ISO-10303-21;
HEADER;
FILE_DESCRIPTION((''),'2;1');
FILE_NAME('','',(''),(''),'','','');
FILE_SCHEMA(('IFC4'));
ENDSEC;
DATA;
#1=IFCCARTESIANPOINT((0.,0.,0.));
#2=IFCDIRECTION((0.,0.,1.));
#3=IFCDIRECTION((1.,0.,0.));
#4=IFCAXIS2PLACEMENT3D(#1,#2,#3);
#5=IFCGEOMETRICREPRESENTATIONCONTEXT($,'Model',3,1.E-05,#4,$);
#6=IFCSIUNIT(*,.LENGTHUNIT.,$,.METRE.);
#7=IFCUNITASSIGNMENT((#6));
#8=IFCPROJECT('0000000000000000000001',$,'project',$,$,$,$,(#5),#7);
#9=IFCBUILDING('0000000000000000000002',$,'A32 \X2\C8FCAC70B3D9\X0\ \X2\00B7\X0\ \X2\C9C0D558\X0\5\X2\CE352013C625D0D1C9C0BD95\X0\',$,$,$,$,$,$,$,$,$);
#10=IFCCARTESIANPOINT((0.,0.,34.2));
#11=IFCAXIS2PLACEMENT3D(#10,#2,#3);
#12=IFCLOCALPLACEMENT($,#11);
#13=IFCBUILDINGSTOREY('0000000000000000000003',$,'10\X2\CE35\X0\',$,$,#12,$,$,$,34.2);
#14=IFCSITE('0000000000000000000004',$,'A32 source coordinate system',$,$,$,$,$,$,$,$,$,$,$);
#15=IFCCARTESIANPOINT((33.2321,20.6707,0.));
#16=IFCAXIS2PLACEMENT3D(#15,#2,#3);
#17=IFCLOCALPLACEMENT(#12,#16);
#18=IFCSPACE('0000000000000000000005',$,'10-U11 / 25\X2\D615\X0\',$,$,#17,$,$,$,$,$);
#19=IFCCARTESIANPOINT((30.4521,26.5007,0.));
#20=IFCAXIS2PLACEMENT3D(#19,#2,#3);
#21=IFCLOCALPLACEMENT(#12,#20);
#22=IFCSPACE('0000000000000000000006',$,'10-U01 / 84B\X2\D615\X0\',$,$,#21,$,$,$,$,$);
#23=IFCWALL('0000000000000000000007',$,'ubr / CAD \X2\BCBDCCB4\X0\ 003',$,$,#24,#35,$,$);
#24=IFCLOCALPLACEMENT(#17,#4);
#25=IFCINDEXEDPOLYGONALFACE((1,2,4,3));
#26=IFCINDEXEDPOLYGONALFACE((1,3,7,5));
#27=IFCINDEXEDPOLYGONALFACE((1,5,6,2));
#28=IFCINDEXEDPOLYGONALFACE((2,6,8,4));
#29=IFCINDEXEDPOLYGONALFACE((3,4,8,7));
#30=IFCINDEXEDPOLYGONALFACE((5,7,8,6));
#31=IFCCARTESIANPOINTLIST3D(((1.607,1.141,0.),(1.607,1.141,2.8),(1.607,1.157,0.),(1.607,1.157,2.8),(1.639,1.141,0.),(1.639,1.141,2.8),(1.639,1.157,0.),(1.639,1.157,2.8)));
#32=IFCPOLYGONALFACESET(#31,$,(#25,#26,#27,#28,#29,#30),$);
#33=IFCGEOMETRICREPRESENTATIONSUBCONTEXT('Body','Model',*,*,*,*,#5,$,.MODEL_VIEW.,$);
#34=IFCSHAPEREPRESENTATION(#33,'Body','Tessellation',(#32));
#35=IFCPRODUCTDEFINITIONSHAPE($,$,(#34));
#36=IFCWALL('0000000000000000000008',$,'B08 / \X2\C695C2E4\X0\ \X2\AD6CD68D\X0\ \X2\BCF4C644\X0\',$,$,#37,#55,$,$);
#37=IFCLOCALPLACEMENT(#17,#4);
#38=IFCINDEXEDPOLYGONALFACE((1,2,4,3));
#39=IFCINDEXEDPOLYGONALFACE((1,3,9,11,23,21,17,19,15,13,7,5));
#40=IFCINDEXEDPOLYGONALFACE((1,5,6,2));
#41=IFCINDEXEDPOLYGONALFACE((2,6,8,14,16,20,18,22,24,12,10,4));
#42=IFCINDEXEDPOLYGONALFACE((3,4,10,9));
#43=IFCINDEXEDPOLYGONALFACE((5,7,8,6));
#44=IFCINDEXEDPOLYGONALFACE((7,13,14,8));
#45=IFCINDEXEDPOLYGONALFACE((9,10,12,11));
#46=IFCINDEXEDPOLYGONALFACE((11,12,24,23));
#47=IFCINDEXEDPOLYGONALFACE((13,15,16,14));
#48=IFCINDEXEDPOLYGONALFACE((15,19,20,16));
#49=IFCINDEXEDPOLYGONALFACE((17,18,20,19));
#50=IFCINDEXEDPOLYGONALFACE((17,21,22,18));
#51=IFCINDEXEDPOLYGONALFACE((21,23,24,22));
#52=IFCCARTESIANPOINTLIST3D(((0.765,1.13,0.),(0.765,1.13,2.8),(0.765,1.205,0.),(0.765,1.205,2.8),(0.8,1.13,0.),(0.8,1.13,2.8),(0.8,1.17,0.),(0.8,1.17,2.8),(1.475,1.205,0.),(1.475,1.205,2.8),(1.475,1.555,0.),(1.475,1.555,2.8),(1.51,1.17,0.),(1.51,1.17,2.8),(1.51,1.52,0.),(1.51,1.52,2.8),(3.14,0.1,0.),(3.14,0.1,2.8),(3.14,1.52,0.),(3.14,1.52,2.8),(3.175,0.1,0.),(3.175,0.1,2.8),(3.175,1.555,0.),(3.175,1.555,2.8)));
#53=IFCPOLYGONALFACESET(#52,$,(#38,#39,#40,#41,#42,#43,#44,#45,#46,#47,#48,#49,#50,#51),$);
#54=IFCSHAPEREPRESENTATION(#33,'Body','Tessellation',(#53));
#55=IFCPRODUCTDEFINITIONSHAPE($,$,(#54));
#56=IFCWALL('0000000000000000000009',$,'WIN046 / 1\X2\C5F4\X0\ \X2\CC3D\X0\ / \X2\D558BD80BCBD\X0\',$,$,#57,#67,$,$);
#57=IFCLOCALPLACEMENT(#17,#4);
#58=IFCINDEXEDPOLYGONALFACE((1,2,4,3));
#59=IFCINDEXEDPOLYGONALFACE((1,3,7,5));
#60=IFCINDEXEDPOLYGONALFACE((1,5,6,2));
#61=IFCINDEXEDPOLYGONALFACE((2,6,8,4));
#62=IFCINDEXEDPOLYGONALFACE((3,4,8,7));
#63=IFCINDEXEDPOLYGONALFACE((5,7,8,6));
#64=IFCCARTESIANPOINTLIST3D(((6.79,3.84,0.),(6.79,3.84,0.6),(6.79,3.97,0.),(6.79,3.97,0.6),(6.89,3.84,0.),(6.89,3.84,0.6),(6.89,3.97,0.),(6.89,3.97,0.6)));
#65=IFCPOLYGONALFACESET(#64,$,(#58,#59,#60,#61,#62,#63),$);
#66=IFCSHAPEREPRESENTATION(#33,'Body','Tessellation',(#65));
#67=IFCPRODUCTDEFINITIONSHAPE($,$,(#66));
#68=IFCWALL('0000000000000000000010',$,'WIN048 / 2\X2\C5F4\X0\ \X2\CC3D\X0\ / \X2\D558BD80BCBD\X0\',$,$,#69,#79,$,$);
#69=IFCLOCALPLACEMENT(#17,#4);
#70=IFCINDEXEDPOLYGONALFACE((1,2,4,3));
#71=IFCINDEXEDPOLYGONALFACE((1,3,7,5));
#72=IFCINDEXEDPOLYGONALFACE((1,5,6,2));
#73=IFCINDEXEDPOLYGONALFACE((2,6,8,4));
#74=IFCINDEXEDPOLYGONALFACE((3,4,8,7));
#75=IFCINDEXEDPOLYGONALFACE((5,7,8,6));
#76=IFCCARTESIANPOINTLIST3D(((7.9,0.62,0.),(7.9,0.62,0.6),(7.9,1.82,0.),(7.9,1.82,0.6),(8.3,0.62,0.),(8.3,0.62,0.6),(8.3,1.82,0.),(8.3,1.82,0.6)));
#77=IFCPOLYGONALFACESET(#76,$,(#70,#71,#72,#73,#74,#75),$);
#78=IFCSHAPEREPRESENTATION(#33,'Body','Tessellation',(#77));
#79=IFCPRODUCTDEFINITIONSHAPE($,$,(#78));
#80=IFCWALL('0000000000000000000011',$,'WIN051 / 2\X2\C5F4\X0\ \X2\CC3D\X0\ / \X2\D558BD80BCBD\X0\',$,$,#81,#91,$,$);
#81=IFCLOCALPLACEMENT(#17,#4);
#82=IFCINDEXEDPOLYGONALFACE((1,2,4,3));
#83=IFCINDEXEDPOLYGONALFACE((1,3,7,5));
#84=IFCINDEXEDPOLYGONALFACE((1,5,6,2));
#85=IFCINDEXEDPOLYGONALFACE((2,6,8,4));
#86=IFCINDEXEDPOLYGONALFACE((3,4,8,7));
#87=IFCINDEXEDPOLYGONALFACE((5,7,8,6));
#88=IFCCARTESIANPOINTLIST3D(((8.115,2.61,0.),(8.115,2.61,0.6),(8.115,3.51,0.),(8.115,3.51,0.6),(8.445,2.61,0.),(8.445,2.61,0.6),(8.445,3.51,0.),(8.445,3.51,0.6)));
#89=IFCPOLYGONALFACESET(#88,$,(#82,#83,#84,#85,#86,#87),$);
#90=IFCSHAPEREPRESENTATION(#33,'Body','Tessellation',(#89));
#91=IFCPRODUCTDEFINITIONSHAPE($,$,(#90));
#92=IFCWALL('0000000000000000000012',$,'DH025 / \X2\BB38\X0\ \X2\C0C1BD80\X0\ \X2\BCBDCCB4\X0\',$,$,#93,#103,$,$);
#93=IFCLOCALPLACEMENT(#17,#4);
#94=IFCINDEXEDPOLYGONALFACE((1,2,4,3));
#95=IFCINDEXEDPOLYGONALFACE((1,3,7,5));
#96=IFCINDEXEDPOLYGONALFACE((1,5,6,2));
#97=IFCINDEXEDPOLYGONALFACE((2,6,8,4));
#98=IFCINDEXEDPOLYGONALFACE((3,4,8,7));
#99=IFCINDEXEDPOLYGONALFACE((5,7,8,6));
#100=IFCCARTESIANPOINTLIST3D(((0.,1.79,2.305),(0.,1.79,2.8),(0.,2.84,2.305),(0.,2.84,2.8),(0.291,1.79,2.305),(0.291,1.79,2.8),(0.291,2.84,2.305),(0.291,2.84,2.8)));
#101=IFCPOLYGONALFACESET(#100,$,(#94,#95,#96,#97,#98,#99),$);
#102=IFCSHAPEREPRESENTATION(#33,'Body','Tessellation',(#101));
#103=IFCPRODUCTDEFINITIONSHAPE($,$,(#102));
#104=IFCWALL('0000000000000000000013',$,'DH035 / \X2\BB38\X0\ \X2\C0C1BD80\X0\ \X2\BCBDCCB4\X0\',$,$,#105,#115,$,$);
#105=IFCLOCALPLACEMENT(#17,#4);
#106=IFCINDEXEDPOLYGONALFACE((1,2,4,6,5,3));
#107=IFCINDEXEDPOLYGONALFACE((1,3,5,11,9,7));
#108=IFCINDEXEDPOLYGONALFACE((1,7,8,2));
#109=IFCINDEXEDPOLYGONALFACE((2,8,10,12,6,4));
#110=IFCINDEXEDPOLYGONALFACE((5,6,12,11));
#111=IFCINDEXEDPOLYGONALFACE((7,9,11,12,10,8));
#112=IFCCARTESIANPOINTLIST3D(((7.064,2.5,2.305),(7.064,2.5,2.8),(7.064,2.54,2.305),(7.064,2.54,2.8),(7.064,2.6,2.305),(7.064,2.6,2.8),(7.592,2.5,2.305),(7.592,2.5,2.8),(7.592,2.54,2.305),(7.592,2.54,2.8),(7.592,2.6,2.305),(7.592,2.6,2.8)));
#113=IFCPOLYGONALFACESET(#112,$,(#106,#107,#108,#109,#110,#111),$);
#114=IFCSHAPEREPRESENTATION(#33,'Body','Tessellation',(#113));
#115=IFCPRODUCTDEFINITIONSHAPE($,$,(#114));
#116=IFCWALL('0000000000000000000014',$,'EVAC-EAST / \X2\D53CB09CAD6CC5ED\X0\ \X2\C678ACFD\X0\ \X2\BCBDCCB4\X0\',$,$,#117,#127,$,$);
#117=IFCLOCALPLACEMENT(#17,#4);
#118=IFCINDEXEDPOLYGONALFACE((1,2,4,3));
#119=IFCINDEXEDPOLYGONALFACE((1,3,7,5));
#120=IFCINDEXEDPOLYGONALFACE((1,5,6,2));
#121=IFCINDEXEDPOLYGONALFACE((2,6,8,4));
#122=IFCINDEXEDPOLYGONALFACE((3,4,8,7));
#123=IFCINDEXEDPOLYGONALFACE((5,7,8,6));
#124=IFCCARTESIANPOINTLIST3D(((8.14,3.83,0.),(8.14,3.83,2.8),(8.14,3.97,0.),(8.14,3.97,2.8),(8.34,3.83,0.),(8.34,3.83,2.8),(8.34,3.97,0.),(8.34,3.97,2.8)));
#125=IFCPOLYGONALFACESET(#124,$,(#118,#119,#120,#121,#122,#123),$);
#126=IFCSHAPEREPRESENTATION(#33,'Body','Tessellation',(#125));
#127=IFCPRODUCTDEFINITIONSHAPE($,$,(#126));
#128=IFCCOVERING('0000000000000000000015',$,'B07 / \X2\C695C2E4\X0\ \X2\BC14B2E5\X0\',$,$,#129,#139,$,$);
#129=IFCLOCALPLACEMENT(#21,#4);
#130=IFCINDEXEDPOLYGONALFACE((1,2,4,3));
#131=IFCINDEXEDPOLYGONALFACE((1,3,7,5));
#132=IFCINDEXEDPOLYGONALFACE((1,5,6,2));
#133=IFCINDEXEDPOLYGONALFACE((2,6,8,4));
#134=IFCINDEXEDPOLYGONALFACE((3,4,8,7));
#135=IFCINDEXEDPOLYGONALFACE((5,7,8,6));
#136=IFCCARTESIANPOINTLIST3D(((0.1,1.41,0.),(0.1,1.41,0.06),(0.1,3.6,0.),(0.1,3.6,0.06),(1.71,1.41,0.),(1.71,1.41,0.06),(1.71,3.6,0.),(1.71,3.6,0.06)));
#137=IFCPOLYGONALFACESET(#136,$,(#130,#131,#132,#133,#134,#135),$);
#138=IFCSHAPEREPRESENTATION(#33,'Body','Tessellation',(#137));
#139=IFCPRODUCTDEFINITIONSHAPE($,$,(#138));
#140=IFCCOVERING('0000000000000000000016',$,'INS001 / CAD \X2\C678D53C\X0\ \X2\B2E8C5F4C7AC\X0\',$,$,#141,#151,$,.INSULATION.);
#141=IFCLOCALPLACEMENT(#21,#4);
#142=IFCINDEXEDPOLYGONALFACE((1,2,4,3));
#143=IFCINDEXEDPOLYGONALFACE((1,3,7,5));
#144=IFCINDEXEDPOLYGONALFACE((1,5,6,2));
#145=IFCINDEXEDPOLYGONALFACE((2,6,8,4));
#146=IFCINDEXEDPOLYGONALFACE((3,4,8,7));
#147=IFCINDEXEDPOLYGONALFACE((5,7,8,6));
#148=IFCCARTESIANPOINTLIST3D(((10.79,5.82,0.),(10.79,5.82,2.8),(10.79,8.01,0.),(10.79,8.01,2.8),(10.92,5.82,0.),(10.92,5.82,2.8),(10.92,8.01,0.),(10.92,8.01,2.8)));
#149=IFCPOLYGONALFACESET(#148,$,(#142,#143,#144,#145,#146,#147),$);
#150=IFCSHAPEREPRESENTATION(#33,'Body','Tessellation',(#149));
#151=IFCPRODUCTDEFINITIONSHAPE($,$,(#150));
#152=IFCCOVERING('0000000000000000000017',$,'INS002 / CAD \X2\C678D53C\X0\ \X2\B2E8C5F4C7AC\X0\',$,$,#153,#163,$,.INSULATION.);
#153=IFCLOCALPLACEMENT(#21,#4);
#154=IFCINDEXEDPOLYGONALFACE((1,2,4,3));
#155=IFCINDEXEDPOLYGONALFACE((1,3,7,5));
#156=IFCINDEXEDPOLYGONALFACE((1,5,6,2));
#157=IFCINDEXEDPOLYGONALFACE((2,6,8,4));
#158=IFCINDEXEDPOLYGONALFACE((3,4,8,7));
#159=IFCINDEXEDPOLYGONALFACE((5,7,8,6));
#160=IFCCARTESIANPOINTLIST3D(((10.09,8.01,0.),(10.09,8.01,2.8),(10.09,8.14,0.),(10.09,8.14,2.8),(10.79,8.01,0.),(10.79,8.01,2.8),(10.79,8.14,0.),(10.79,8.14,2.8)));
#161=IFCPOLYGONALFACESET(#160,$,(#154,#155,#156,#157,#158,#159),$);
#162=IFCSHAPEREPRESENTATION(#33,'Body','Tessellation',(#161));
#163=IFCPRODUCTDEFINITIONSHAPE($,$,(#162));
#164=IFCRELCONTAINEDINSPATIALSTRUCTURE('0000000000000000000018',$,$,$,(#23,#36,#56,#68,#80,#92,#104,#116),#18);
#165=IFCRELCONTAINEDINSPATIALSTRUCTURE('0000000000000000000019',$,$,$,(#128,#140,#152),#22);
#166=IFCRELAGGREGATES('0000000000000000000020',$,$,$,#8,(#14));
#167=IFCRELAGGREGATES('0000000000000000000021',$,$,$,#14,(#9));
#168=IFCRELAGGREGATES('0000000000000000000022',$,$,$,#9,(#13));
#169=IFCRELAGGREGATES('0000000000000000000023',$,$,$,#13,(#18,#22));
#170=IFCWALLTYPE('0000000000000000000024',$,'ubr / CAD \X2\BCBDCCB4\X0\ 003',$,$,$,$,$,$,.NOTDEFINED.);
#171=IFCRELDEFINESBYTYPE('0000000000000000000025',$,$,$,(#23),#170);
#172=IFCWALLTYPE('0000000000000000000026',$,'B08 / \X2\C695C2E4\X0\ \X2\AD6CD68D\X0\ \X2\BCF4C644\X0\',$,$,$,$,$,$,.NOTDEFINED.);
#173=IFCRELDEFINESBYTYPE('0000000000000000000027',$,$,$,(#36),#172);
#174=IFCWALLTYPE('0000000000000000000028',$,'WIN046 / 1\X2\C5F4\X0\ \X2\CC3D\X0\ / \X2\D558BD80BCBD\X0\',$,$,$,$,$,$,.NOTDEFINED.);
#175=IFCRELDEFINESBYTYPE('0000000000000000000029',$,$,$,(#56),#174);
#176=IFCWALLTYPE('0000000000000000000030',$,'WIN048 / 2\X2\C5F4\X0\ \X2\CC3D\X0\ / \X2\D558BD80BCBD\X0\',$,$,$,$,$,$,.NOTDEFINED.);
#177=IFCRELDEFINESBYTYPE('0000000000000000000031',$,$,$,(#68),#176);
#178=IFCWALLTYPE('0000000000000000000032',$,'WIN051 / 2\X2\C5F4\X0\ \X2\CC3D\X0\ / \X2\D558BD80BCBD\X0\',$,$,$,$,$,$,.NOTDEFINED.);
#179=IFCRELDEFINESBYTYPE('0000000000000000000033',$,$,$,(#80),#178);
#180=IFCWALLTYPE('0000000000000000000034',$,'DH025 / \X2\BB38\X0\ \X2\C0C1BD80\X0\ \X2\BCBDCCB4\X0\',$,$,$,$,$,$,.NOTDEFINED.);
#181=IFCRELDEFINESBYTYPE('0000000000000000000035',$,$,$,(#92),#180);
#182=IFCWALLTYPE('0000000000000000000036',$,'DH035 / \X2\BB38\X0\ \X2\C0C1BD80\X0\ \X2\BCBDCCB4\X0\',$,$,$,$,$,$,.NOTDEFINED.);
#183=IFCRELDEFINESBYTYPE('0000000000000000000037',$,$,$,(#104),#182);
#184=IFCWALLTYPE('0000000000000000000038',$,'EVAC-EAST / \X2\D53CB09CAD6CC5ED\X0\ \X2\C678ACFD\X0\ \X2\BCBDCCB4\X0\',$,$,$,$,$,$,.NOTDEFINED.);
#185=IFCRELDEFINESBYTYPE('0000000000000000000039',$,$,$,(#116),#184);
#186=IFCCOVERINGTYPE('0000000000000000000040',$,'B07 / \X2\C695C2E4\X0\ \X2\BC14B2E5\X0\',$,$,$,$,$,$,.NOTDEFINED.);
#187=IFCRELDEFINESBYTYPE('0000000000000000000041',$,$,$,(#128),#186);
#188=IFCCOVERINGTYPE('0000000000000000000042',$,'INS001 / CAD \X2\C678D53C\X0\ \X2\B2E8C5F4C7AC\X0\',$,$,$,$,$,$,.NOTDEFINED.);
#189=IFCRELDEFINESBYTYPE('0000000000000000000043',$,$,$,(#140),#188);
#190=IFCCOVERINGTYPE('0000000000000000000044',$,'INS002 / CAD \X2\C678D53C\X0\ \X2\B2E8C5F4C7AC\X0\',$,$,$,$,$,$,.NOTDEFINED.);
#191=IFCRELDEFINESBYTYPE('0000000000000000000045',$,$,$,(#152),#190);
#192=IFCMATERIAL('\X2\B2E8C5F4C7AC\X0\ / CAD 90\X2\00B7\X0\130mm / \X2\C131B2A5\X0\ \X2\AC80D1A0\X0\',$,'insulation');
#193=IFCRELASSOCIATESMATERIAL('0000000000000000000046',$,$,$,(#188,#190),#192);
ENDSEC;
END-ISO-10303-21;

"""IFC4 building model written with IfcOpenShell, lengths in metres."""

from ifc_helpers import new_model, si_unit, frame, origin, origin_with_axes, place, context, subcontext, project, spatial, polyline, outline, extrude, source, transform, mapped, material, type_object, type_shapes, element, save


model = new_model("IFC4")

# Units and contexts
model_context = context("Model", 3, precision=1e-05, world=origin_with_axes())
body_context = subcontext(model_context, "Body", "Model", "MODEL_VIEW")
ifc_project = project(units=[si_unit("LENGTHUNIT", "METRE")], contexts=[model_context])

# Site, building, storey, space
site = spatial("IfcSite", under=ifc_project, Name="A32 source coordinate system")
building = spatial("IfcBuilding", under=site, Name="A32 주거동 · 지하5층–옥탑지붕")
storey_placement = place(None, frame((0.0, 0.0, 34.2), z_axis=(0.0, 0.0, 1.0), x_axis=(1.0, 0.0, 0.0)))
storey = spatial("IfcBuildingStorey", under=building, at=storey_placement, Name="10층", Elevation=34.2)
space_1_placement = place(storey_placement, frame((33.2321, 20.6707, 0.0), z_axis=(0.0, 0.0, 1.0), x_axis=(1.0, 0.0, 0.0)))
space_1 = spatial("IfcSpace", under=storey, at=space_1_placement, Name="10-U11 / 25형")

# Walls
wall_type_1 = type_object("IfcWallType", Name="ubr / CAD 벽체 003", PredefinedType="NOTDEFINED")
shared_shape_1 = source(origin(), body_context, "Body", "SweptSolid", [
    extrude(outline(polyline([(1.639, 1.157), (1.639, 1.141), (1.607, 1.141), (1.607, 1.157), (1.639, 1.157)])), origin(), (0.0, 0.0, 1.0), 2.8),
])
type_shapes(wall_type_1, [shared_shape_1])
wall_1_placement = place(space_1_placement, origin_with_axes())
element("IfcWall", 1, at=wall_1_placement, inside=space_1, type_object=wall_type_1, Name="ubr / CAD 벽체 003", context=body_context, shape_type="MappedRepresentation", body=[
    mapped(shared_shape_1, transform((0.0, 0.0, 0.0), scale=1.0)),
])
wall_type_2 = type_object("IfcWallType", Name="B08 / 욕실 구획 보완", PredefinedType="NOTDEFINED")
shared_shape_2 = source(origin(), body_context, "Body", "SweptSolid", [
    extrude(outline(polyline([(0.765, 1.205), (1.475, 1.205), (1.475, 1.555), (3.175, 1.555), (3.175, 0.1), (3.14, 0.1), (3.14, 1.52), (1.51, 1.52), (1.51, 1.17), (0.8, 1.17), (0.8, 1.13), (0.765, 1.13), (0.765, 1.205)])), origin(), (0.0, 0.0, 1.0), 2.8),
])
type_shapes(wall_type_2, [shared_shape_2])
wall_2_placement = place(space_1_placement, origin_with_axes())
element("IfcWall", 2, at=wall_2_placement, inside=space_1, type_object=wall_type_2, Name="B08 / 욕실 구획 보완", context=body_context, shape_type="MappedRepresentation", body=[
    mapped(shared_shape_2, transform((0.0, 0.0, 0.0), scale=1.0)),
])
wall_type_3 = type_object("IfcWallType", Name="WIN046 / 1열 창 / 하부벽", PredefinedType="NOTDEFINED")
shared_shape_3 = source(origin(), body_context, "Body", "SweptSolid", [
    extrude(outline(polyline([(6.89, 3.84), (6.79, 3.84), (6.79, 3.97), (6.89, 3.97), (6.89, 3.84)])), origin(), (0.0, 0.0, 1.0), 0.6),
])
type_shapes(wall_type_3, [shared_shape_3])
wall_3_placement = place(space_1_placement, origin_with_axes())
element("IfcWall", 3, at=wall_3_placement, inside=space_1, type_object=wall_type_3, Name="WIN046 / 1열 창 / 하부벽", context=body_context, shape_type="MappedRepresentation", body=[
    mapped(shared_shape_3, transform((0.0, 0.0, 0.0), scale=1.0)),
])
wall_type_4 = type_object("IfcWallType", Name="WIN048 / 2열 창 / 하부벽", PredefinedType="NOTDEFINED")
shared_shape_4 = source(origin(), body_context, "Body", "SweptSolid", [
    extrude(outline(polyline([(8.3, 0.62), (7.9, 0.62), (7.9, 1.82), (8.3, 1.82), (8.3, 0.62)])), origin(), (0.0, 0.0, 1.0), 0.6),
])
type_shapes(wall_type_4, [shared_shape_4])
wall_4_placement = place(space_1_placement, origin_with_axes())
element("IfcWall", 4, at=wall_4_placement, inside=space_1, type_object=wall_type_4, Name="WIN048 / 2열 창 / 하부벽", context=body_context, shape_type="MappedRepresentation", body=[
    mapped(shared_shape_4, transform((0.0, 0.0, 0.0), scale=1.0)),
])
wall_type_5 = type_object("IfcWallType", Name="WIN051 / 2열 창 / 하부벽", PredefinedType="NOTDEFINED")
shared_shape_5 = source(origin(), body_context, "Body", "SweptSolid", [
    extrude(outline(polyline([(8.445, 2.61), (8.115, 2.61), (8.115, 3.51), (8.445, 3.51), (8.445, 2.61)])), origin(), (0.0, 0.0, 1.0), 0.6),
])
type_shapes(wall_type_5, [shared_shape_5])
wall_5_placement = place(space_1_placement, origin_with_axes())
element("IfcWall", 5, at=wall_5_placement, inside=space_1, type_object=wall_type_5, Name="WIN051 / 2열 창 / 하부벽", context=body_context, shape_type="MappedRepresentation", body=[
    mapped(shared_shape_5, transform((0.0, 0.0, 0.0), scale=1.0)),
])
wall_type_6 = type_object("IfcWallType", Name="DH025 / 문 상부 벽체", PredefinedType="NOTDEFINED")
shared_shape_6 = source(origin(), body_context, "Body", "SweptSolid", [
    extrude(outline(polyline([(0.0, 1.79), (0.0, 2.84), (0.291, 2.84), (0.291, 1.79), (0.0, 1.79)])), frame((0.0, 0.0, 2.305)), (0.0, 0.0, 1.0), 0.495),
])
type_shapes(wall_type_6, [shared_shape_6])
wall_6_placement = place(space_1_placement, origin_with_axes())
element("IfcWall", 6, at=wall_6_placement, inside=space_1, type_object=wall_type_6, Name="DH025 / 문 상부 벽체", context=body_context, shape_type="MappedRepresentation", body=[
    mapped(shared_shape_6, transform((0.0, 0.0, 0.0), scale=1.0)),
])
wall_type_7 = type_object("IfcWallType", Name="DH035 / 문 상부 벽체", PredefinedType="NOTDEFINED")
shared_shape_7 = source(origin(), body_context, "Body", "SweptSolid", [
    extrude(outline(polyline([(7.592, 2.6), (7.592, 2.54), (7.592, 2.5), (7.064, 2.5), (7.064, 2.54), (7.064, 2.6), (7.592, 2.6)])), frame((0.0, 0.0, 2.305)), (0.0, 0.0, 1.0), 0.495),
])
type_shapes(wall_type_7, [shared_shape_7])
wall_7_placement = place(space_1_placement, origin_with_axes())
element("IfcWall", 7, at=wall_7_placement, inside=space_1, type_object=wall_type_7, Name="DH035 / 문 상부 벽체", context=body_context, shape_type="MappedRepresentation", body=[
    mapped(shared_shape_7, transform((0.0, 0.0, 0.0), scale=1.0)),
])
wall_type_8 = type_object("IfcWallType", Name="EVAC-EAST / 피난구역 외곽 벽체", PredefinedType="NOTDEFINED")
shared_shape_8 = source(origin(), body_context, "Body", "SweptSolid", [
    extrude(outline(polyline([(8.34, 3.83), (8.14, 3.83), (8.14, 3.97), (8.34, 3.97), (8.34, 3.83)])), origin(), (0.0, 0.0, 1.0), 2.8),
])
type_shapes(wall_type_8, [shared_shape_8])
wall_8_placement = place(space_1_placement, origin_with_axes())
element("IfcWall", 8, at=wall_8_placement, inside=space_1, type_object=wall_type_8, Name="EVAC-EAST / 피난구역 외곽 벽체", context=body_context, shape_type="MappedRepresentation", body=[
    mapped(shared_shape_8, transform((0.0, 0.0, 0.0), scale=1.0)),
])

# Shared definitions
space_2_placement = place(storey_placement, frame((30.4521, 26.5007, 0.0), z_axis=(0.0, 0.0, 1.0), x_axis=(1.0, 0.0, 0.0)))
space_2 = spatial("IfcSpace", under=storey, at=space_2_placement, Name="10-U01 / 84B형")

# Coverings
covering_type_1 = type_object("IfcCoveringType", Name="B07 / 욕실 바닥", PredefinedType="NOTDEFINED")
shared_shape_9 = source(origin(), body_context, "Body", "SweptSolid", [
    extrude(outline(polyline([(1.71, 1.41), (0.1, 1.41), (0.1, 3.6), (1.71, 3.6), (1.71, 1.41)])), origin(), (0.0, 0.0, 1.0), 0.06),
])
type_shapes(covering_type_1, [shared_shape_9])
covering_1_placement = place(space_2_placement, origin_with_axes())
element("IfcCovering", 9, at=covering_1_placement, inside=space_2, type_object=covering_type_1, Name="B07 / 욕실 바닥", context=body_context, shape_type="MappedRepresentation", body=[
    mapped(shared_shape_9, transform((0.0, 0.0, 0.0), scale=1.0)),
])
ifc_material = material(Name="단열재 / CAD 90·130mm / 성능 검토", Category="insulation")
covering_type_2 = type_object("IfcCoveringType", Name="INS001 / CAD 외피 단열재", PredefinedType="NOTDEFINED", material=ifc_material)
shared_shape_10 = source(origin(), body_context, "Body", "SweptSolid", [
    extrude(outline(polyline([(10.79, 5.82), (10.79, 8.01), (10.92, 8.01), (10.92, 5.82), (10.79, 5.82)])), origin(), (0.0, 0.0, 1.0), 2.8),
])
type_shapes(covering_type_2, [shared_shape_10])
covering_2_placement = place(space_2_placement, origin_with_axes())
element("IfcCovering", 10, at=covering_2_placement, inside=space_2, type_object=covering_type_2, Name="INS001 / CAD 외피 단열재", PredefinedType="INSULATION", context=body_context, shape_type="MappedRepresentation", body=[
    mapped(shared_shape_10, transform((0.0, 0.0, 0.0), scale=1.0)),
])
covering_type_3 = type_object("IfcCoveringType", Name="INS002 / CAD 외피 단열재", PredefinedType="NOTDEFINED", material=ifc_material)
shared_shape_11 = source(origin(), body_context, "Body", "SweptSolid", [
    extrude(outline(polyline([(10.79, 8.01), (10.09, 8.01), (10.09, 8.14), (10.79, 8.14), (10.79, 8.01)])), origin(), (0.0, 0.0, 1.0), 2.8),
])
type_shapes(covering_type_3, [shared_shape_11])
covering_3_placement = place(space_2_placement, origin_with_axes())
element("IfcCovering", 11, at=covering_3_placement, inside=space_2, type_object=covering_type_3, Name="INS002 / CAD 외피 단열재", PredefinedType="INSULATION", context=body_context, shape_type="MappedRepresentation", body=[
    mapped(shared_shape_11, transform((0.0, 0.0, 0.0), scale=1.0)),
])

save(model, "model.ifc")
